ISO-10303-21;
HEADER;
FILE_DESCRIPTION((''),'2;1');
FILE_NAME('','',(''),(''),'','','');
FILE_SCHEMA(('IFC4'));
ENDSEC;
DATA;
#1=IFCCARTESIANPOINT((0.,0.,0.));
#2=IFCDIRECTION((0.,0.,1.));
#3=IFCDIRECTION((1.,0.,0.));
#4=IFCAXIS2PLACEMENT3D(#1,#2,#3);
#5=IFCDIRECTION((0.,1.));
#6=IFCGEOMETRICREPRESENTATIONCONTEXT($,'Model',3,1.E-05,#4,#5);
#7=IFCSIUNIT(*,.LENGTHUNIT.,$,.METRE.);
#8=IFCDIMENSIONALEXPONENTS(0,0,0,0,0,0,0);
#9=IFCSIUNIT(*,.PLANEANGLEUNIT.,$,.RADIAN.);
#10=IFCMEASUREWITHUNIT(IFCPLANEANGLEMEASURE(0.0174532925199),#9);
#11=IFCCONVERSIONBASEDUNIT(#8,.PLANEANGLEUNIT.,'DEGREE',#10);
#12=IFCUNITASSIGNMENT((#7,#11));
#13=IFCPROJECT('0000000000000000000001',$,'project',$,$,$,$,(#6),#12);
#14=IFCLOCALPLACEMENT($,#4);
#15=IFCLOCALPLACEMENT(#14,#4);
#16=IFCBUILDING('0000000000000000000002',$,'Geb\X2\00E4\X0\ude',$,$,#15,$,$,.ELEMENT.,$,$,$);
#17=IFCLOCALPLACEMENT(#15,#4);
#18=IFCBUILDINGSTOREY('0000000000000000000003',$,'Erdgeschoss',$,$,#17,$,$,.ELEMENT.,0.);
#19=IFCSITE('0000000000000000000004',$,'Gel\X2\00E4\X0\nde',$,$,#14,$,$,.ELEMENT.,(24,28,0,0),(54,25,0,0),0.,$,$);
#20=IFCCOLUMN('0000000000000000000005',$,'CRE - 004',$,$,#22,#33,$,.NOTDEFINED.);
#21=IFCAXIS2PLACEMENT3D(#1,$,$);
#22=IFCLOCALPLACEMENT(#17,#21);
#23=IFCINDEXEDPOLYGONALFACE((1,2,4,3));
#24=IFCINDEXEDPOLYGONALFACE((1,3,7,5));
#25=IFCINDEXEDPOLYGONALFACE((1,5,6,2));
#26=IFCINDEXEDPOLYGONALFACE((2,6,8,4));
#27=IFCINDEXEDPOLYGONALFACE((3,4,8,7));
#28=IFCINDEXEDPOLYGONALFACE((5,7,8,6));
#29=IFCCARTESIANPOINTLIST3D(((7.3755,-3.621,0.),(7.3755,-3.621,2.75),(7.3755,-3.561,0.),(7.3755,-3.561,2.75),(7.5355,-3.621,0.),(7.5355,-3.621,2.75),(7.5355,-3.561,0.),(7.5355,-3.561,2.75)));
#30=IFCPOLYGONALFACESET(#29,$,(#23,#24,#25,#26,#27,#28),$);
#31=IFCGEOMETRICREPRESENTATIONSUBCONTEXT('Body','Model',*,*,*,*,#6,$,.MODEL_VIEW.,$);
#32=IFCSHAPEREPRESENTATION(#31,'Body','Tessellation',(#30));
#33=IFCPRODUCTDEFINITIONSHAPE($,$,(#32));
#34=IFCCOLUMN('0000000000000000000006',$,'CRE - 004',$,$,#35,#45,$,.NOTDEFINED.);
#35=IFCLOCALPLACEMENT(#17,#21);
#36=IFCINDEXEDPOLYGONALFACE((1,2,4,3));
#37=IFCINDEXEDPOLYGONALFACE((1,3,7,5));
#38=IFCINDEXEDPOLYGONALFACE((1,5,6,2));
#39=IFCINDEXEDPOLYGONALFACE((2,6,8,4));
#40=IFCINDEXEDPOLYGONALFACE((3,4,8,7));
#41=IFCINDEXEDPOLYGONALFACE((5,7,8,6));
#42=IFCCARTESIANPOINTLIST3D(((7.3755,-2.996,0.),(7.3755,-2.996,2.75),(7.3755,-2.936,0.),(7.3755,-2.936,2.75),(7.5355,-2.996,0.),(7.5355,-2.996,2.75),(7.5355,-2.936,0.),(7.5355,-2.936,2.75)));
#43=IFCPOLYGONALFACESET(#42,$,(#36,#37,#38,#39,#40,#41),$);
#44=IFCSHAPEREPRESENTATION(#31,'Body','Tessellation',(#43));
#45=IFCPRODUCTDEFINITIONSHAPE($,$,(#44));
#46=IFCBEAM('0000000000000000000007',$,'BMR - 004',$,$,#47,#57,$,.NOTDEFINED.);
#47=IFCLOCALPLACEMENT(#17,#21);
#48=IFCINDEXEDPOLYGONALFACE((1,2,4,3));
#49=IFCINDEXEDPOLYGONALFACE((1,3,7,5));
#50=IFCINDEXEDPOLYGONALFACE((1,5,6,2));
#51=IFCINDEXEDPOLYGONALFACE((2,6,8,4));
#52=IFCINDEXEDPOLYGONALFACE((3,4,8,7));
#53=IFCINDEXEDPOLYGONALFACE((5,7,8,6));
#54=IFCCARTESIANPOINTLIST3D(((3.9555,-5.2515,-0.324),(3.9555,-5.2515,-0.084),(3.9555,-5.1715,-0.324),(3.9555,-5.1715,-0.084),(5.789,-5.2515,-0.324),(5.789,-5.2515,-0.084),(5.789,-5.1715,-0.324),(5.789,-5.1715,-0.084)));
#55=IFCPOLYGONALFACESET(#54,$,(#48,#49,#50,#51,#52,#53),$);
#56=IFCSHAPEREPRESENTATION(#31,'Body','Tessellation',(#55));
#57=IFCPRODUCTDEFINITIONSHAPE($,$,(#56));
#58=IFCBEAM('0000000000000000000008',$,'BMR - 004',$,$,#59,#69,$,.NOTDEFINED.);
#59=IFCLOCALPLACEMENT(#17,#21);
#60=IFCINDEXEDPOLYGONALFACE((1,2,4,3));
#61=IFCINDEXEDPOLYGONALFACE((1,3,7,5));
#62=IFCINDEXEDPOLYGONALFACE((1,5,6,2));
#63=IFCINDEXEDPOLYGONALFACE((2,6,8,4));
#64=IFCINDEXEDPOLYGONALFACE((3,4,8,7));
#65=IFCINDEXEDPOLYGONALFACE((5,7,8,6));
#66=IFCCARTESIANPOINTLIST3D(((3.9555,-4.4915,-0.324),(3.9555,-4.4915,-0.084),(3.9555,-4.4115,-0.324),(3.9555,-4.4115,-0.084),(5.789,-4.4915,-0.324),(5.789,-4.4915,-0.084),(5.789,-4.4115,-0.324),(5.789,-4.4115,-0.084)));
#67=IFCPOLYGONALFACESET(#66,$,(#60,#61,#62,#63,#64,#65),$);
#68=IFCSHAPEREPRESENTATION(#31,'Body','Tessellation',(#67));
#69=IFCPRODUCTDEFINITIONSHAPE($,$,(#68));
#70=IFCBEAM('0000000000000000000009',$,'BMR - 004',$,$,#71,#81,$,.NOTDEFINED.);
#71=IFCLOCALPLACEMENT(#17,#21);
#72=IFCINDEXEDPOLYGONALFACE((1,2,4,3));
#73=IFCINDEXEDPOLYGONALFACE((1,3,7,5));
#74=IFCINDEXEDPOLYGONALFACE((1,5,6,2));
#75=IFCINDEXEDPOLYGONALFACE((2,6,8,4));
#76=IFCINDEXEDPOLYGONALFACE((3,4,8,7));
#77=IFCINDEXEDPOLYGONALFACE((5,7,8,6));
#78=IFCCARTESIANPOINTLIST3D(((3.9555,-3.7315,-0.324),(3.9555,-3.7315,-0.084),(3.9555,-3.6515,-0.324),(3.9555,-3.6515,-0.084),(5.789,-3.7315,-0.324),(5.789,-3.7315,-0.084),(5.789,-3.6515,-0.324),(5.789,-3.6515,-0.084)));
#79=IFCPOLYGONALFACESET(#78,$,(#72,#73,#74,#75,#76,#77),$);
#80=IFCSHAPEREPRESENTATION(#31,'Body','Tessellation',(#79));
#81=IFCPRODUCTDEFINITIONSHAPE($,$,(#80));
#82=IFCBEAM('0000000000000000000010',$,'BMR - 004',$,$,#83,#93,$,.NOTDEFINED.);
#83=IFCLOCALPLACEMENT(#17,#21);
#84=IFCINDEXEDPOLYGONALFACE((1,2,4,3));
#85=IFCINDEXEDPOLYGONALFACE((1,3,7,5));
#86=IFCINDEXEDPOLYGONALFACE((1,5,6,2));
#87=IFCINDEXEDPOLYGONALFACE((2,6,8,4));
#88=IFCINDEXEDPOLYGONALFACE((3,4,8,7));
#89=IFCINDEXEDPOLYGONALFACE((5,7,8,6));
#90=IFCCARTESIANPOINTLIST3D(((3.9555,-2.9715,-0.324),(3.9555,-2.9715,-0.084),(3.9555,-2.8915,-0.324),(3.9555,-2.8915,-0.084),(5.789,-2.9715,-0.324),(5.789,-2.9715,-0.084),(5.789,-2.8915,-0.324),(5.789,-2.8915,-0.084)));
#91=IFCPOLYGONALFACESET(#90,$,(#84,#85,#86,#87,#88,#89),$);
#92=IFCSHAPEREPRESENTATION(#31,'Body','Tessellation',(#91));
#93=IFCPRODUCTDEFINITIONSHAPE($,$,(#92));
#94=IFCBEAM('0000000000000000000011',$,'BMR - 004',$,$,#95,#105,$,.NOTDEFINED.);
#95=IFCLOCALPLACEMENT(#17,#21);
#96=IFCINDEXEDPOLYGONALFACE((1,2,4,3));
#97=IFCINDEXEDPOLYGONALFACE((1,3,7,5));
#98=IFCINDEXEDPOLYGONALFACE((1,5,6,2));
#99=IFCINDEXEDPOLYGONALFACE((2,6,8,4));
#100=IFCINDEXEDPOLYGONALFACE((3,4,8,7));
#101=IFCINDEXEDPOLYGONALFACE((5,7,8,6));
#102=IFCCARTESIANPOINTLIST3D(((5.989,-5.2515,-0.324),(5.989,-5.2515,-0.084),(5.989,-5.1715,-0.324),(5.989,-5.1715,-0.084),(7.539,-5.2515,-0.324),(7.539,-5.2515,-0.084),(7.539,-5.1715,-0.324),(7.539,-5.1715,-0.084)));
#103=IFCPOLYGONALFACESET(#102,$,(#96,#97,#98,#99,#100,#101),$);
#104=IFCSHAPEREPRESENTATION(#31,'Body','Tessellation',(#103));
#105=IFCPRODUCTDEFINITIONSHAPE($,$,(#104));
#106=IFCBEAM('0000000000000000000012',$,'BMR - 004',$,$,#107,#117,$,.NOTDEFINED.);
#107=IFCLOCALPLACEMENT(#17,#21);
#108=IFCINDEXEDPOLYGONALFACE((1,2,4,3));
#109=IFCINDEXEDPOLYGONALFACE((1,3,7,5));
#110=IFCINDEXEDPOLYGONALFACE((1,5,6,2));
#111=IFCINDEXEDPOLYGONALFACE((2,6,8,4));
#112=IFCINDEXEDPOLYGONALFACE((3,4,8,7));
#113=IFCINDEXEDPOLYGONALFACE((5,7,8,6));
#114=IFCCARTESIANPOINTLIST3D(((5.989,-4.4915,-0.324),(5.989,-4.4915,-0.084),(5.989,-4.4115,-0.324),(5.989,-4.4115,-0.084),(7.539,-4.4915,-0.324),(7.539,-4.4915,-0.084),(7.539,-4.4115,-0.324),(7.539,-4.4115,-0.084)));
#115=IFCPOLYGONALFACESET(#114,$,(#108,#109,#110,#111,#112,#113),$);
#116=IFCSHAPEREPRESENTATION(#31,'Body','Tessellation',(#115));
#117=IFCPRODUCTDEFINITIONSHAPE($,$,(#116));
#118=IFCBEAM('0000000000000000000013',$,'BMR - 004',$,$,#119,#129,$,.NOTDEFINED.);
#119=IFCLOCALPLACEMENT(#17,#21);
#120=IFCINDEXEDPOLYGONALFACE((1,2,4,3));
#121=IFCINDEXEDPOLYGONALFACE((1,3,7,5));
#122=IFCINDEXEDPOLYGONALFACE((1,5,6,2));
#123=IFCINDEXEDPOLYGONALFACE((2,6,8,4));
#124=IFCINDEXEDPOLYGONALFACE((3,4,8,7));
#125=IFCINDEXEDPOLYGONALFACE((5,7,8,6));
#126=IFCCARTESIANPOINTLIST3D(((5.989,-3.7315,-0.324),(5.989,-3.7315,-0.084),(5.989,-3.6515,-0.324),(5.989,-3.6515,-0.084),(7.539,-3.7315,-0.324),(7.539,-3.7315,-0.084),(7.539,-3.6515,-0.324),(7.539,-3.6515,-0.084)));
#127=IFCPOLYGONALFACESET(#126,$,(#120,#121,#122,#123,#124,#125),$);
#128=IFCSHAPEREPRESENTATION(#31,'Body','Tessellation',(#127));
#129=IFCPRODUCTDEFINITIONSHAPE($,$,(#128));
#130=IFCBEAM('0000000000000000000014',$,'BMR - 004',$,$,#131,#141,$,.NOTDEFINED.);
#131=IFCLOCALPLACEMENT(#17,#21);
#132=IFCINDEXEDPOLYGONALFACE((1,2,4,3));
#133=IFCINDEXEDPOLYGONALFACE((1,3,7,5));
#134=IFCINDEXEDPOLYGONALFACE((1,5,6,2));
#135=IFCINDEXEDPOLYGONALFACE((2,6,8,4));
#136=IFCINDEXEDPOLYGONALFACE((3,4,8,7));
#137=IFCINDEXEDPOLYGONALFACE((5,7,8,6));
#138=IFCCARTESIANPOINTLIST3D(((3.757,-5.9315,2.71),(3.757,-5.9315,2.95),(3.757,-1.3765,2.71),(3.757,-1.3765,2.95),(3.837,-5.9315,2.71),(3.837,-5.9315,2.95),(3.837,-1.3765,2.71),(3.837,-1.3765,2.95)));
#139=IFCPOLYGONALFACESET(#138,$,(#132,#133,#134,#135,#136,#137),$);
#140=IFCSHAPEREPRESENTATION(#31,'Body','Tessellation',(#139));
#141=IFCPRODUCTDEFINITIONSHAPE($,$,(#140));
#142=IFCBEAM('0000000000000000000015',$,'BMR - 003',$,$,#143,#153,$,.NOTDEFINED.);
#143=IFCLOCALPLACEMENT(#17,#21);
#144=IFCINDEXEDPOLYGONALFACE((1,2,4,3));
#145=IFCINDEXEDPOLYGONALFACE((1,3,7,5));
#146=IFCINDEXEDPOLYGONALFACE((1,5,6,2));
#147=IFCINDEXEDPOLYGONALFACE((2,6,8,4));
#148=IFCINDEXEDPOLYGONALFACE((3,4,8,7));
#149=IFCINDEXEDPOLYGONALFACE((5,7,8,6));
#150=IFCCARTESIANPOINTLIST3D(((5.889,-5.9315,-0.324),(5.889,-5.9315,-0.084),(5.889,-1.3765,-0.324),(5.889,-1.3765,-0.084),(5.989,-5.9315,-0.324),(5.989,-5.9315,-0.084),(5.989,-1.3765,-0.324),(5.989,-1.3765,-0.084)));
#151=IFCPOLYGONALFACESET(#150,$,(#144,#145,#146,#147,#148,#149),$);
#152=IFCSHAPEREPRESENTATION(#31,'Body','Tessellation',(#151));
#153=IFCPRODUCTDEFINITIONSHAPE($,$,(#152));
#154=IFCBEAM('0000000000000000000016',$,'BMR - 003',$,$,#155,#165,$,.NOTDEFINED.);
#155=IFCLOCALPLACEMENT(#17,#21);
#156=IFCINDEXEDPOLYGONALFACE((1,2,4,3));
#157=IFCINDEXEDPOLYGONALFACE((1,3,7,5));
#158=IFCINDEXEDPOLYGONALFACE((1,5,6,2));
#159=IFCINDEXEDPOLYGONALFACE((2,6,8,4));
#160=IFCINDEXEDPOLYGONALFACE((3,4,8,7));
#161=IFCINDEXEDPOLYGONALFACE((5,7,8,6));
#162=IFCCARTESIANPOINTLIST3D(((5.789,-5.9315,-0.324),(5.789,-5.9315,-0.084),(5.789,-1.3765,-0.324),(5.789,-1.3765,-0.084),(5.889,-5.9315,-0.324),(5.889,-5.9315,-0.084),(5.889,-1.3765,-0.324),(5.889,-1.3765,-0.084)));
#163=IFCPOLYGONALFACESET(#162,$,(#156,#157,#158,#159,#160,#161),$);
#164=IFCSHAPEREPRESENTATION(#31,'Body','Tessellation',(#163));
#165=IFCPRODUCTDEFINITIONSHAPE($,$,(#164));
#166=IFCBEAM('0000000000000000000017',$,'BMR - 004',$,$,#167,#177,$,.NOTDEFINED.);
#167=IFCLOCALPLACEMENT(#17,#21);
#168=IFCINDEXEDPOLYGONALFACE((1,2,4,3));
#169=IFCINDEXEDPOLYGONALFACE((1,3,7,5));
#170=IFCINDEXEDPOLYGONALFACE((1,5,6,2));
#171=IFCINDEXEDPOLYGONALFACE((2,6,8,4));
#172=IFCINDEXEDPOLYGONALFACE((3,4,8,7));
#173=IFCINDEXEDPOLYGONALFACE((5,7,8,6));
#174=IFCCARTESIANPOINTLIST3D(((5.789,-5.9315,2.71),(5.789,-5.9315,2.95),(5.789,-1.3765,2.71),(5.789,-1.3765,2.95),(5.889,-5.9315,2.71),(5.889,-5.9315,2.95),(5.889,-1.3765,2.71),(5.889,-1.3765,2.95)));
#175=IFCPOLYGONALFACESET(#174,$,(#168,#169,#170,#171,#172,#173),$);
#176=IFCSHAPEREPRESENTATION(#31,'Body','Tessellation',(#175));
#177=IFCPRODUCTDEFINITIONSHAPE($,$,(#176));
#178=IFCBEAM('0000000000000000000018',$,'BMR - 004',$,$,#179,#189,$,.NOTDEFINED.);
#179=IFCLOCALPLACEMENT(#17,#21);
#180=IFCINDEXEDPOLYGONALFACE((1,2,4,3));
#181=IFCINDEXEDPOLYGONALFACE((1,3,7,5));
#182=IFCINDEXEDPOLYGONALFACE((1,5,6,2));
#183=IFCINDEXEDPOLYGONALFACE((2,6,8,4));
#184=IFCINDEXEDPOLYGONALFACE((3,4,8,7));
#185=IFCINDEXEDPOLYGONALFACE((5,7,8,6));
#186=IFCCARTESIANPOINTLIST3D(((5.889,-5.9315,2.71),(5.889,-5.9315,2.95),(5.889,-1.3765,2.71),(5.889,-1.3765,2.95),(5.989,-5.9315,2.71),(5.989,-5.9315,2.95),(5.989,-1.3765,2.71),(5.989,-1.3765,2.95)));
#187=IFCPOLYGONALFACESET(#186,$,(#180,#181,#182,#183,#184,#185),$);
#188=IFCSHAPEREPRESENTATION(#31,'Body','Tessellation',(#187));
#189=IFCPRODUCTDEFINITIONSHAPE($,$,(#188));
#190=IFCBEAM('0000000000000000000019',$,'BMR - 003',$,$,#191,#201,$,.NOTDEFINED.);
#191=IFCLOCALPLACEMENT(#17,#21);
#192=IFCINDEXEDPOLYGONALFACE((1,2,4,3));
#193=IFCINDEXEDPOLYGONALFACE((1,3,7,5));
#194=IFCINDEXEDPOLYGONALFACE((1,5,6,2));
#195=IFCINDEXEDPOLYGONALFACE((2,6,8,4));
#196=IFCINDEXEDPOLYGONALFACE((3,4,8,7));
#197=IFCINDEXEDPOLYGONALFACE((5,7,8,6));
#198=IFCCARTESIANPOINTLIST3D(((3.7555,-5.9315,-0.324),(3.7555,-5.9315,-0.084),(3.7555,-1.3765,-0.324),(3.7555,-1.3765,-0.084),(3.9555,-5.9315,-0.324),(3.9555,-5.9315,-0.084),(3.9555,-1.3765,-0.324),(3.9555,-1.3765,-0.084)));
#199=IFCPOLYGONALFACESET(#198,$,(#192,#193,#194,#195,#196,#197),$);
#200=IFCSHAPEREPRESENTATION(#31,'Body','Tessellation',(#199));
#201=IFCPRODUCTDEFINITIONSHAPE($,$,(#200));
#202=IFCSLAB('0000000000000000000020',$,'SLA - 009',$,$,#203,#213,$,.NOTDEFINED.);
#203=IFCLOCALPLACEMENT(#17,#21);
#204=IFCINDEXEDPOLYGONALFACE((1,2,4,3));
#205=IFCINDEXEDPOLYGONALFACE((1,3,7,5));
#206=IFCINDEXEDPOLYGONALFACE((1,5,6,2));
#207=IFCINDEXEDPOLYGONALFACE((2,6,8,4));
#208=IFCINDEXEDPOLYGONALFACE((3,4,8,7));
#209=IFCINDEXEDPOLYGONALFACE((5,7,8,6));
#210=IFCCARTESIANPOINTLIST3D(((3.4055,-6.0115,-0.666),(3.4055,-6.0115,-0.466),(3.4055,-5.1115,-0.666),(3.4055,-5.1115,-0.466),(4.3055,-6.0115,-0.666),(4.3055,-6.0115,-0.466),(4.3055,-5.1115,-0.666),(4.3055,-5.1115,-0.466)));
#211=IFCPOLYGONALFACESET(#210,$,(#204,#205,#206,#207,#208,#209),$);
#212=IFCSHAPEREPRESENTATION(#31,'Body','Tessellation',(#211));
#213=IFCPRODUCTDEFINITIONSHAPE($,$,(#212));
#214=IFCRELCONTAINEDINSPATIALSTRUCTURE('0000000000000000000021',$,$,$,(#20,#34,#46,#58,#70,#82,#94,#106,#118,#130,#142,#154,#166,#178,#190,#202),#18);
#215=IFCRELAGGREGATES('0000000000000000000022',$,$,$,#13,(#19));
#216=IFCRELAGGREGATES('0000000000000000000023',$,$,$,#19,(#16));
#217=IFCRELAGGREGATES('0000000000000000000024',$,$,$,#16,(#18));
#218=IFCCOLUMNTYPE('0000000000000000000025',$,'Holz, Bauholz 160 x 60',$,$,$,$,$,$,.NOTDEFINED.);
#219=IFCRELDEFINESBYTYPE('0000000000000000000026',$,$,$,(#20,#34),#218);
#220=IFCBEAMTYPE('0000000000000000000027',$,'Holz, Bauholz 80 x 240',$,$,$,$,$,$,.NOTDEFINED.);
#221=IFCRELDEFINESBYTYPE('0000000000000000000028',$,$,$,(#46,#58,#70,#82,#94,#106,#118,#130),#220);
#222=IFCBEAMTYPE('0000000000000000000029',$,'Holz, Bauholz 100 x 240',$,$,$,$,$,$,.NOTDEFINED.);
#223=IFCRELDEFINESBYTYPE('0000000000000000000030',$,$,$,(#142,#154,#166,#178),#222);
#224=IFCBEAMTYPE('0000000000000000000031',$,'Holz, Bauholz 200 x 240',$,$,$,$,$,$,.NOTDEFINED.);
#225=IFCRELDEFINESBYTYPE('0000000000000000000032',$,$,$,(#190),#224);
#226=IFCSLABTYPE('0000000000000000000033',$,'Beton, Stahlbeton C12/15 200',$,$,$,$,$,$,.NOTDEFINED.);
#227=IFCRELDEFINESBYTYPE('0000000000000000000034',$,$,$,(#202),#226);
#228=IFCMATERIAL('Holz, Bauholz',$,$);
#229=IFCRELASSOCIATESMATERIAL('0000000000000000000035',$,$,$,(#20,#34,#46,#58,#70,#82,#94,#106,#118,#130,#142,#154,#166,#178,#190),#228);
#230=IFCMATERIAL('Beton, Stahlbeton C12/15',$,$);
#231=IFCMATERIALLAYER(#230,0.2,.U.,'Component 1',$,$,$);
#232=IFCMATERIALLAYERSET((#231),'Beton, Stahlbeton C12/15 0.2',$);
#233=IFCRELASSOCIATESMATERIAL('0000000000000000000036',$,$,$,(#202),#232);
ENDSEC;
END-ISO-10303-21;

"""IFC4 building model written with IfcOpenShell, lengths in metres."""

from ifc_helpers import new_model, entity, si_unit, converted_unit, direction, frame, frame_2d, origin_with_axes, origin_2d_with_axis, place, context, subcontext, project, spatial, line, indexed_curve, rectangle, outline, extrude, material, layer, layer_set, layer_usage, type_object, element, save


model = new_model("IFC4")

# Units and contexts
model_context = context("Model", 3, precision=1e-05, world=origin_with_axes(), true_north=direction((0.0, 1.0)))
body_context = subcontext(model_context, "Body", "Model", "MODEL_VIEW")
ifc_project = project(units=[si_unit("LENGTHUNIT", "METRE"), converted_unit("PLANEANGLEUNIT", "DEGREE", entity("IfcPlaneAngleMeasure", 0.0174532925199), si_unit("PLANEANGLEUNIT", "RADIAN"), dimensions=[0, 0, 0, 0, 0, 0, 0])], contexts=[model_context])

# Site, building, storey
site_placement = place(None, origin_with_axes())
site = spatial("IfcSite", under=ifc_project, at=site_placement, Name="Gelände", CompositionType="ELEMENT", RefLatitude=(24, 28, 0, 0), RefLongitude=(54, 25, 0, 0), RefElevation=0.0)
building_placement = place(site_placement, origin_with_axes())
building = spatial("IfcBuilding", under=site, at=building_placement, Name="Gebäude", CompositionType="ELEMENT")
storey_placement = place(building_placement, origin_with_axes())
storey = spatial("IfcBuildingStorey", under=building, at=storey_placement, Name="Erdgeschoss", CompositionType="ELEMENT", Elevation=0.0)

# Columns
ifc_material_1 = material(Name="Holz, Bauholz")
column_type_1 = type_object("IfcColumnType", Name="Holz, Bauholz 160 x 60", PredefinedType="NOTDEFINED")
for number, where, z_axis, x_axis, name in (
    (1, (7.4555, -3.591, 0.0), (0.0, 0.0, 1.0), (0.0, -1.0, 0.0), "CRE - 004"),
    (2, (7.4555, -2.966, 0.0), (0.0, 0.0, 1.0), (0.0, -1.0, 0.0), "CRE - 004"),
):
    element("IfcColumn", number, at=place(storey_placement, frame(where, z_axis=z_axis, x_axis=x_axis)), inside=storey, type_object=column_type_1, material=ifc_material_1, Name=name, PredefinedType="NOTDEFINED", context=body_context, shape_type="SweptSolid", body=[
        extrude(rectangle(XDim=0.16, YDim=0.06, at=origin_2d_with_axis()), frame((0.0, 0.0, 0.0), z_axis=(0.0, 0.0, 1.0), x_axis=(0.0, 1.0, 0.0)), (0.0, 0.0, 1.0), 2.75),
    ])

# Beams
beam_type_1 = type_object("IfcBeamType", Name="Holz, Bauholz 80 x 240", PredefinedType="NOTDEFINED")
for number, where, z_axis, x_axis, name in (
    (3, (5.789, -5.2115, -0.084), (0.0, 0.0, 1.0), (0.0, 1.0, 0.0), "BMR - 004"),
    (4, (5.789, -4.4515, -0.084), (0.0, 0.0, 1.0), (0.0, 1.0, 0.0), "BMR - 004"),
    (5, (5.789, -3.6915, -0.084), (0.0, 0.0, 1.0), (0.0, 1.0, 0.0), "BMR - 004"),
    (6, (5.789, -2.9315, -0.084), (0.0, 0.0, 1.0), (0.0, 1.0, 0.0), "BMR - 004"),
):
    element("IfcBeam", number, at=place(storey_placement, frame(where, z_axis=z_axis, x_axis=x_axis)), inside=storey, type_object=beam_type_1, material=ifc_material_1, Name=name, PredefinedType="NOTDEFINED", context=body_context, shape_type="SweptSolid", body=[
        extrude(rectangle(XDim=0.24, YDim=0.08, at=frame_2d((-0.12, 0.0), x_axis=(1.0, 0.0))), frame((0.0, 0.0, 0.0), z_axis=(0.0, 1.0, 0.0), x_axis=(0.0, 0.0, 1.0)), (0.0, 0.0, 1.0), 1.8335),
    ])
for number, where, z_axis, x_axis, name in (
    (7, (7.539, -5.2115, -0.084), (0.0, 0.0, 1.0), (0.0, 1.0, 0.0), "BMR - 004"),
    (8, (7.539, -4.4515, -0.084), (0.0, 0.0, 1.0), (0.0, 1.0, 0.0), "BMR - 004"),
    (9, (7.539, -3.6915, -0.084), (0.0, 0.0, 1.0), (0.0, 1.0, 0.0), "BMR - 004"),
):
    element("IfcBeam", number, at=place(storey_placement, frame(where, z_axis=z_axis, x_axis=x_axis)), inside=storey, type_object=beam_type_1, material=ifc_material_1, Name=name, PredefinedType="NOTDEFINED", context=body_context, shape_type="SweptSolid", body=[
        extrude(rectangle(XDim=0.24, YDim=0.08, at=frame_2d((-0.12, 0.0), x_axis=(1.0, 0.0))), frame((0.0, 0.0, 0.0), z_axis=(0.0, 1.0, 0.0), x_axis=(0.0, 0.0, 1.0)), (0.0, 0.0, 1.0), 1.55),
    ])
beam_1_placement = place(storey_placement, frame((3.797, -5.9315, 2.95), z_axis=(0.0, 0.0, 1.0), x_axis=(1.0, 0.0, 0.0)))
element("IfcBeam", 10, at=beam_1_placement, inside=storey, type_object=beam_type_1, material=ifc_material_1, Name="BMR - 004", PredefinedType="NOTDEFINED", context=body_context, shape_type="SweptSolid", body=[
    extrude(rectangle(XDim=0.24, YDim=0.08, at=frame_2d((-0.12, 0.0), x_axis=(1.0, 0.0))), frame((0.0, 0.0, 0.0), z_axis=(0.0, 1.0, 0.0), x_axis=(0.0, 0.0, 1.0)), (0.0, 0.0, 1.0), 4.555),
])
beam_type_2 = type_object("IfcBeamType", Name="Holz, Bauholz 100 x 240", PredefinedType="NOTDEFINED")
for number, where, z_axis, x_axis, name in (
    (11, (5.939, -5.9315, -0.084), (0.0, 0.0, 1.0), (1.0, 0.0, 0.0), "BMR - 003"),
    (12, (5.839, -5.9315, -0.084), (0.0, 0.0, 1.0), (1.0, 0.0, 0.0), "BMR - 003"),
):
    element("IfcBeam", number, at=place(storey_placement, frame(where, z_axis=z_axis, x_axis=x_axis)), inside=storey, type_object=beam_type_2, material=ifc_material_1, Name=name, PredefinedType="NOTDEFINED", context=body_context, shape_type="SweptSolid", body=[
        extrude(rectangle(XDim=0.24, YDim=0.1, at=frame_2d((-0.12, 0.0), x_axis=(1.0, 0.0))), frame((0.0, 0.0, 0.0), z_axis=(0.0, 1.0, 0.0), x_axis=(0.0, 0.0, 1.0)), (0.0, 0.0, 1.0), 4.555),
    ])
for number, where, z_axis, x_axis, name in (
    (13, (5.839, -5.9315, 2.95), (0.0, 0.0, 1.0), (1.0, 0.0, 0.0), "BMR - 004"),
    (14, (5.939, -5.9315, 2.95), (0.0, 0.0, 1.0), (1.0, 0.0, 0.0), "BMR - 004"),
):
    element("IfcBeam", number, at=place(storey_placement, frame(where, z_axis=z_axis, x_axis=x_axis)), inside=storey, type_object=beam_type_2, material=ifc_material_1, Name=name, PredefinedType="NOTDEFINED", context=body_context, shape_type="SweptSolid", body=[
        extrude(rectangle(XDim=0.24, YDim=0.1, at=frame_2d((-0.12, 0.0), x_axis=(1.0, 0.0))), frame((0.0, 0.0, 0.0), z_axis=(0.0, 1.0, 0.0), x_axis=(0.0, 0.0, 1.0)), (0.0, 0.0, 1.0), 4.555),
    ])
beam_type_3 = type_object("IfcBeamType", Name="Holz, Bauholz 200 x 240", PredefinedType="NOTDEFINED")
beam_2_placement = place(storey_placement, frame((3.8555, -5.9315, -0.084), z_axis=(0.0, 0.0, 1.0), x_axis=(1.0, 0.0, 0.0)))
element("IfcBeam", 15, at=beam_2_placement, inside=storey, type_object=beam_type_3, material=ifc_material_1, Name="BMR - 003", PredefinedType="NOTDEFINED", context=body_context, shape_type="SweptSolid", body=[
    extrude(rectangle(XDim=0.24, YDim=0.2, at=frame_2d((-0.12, 0.0), x_axis=(1.0, 0.0))), frame((0.0, 0.0, 0.0), z_axis=(0.0, 1.0, 0.0), x_axis=(0.0, 0.0, 1.0)), (0.0, 0.0, 1.0), 4.555),
])

# Slab
ifc_material_2 = material(Name="Beton, Stahlbeton C12/15")
ifc_layer = layer(ifc_material_2, 0.2, ventilated="UNKNOWN", Name="Component 1")
ifc_layer_set = layer_set([ifc_layer], Name="Beton, Stahlbeton C12/15 0.2")
ifc_layer_usage_1 = layer_usage(ifc_layer_set, "AXIS3", "NEGATIVE", 0.2)
slab_type = type_object("IfcSlabType", Name="Beton, Stahlbeton C12/15 200", PredefinedType="NOTDEFINED")
slab_1_placement = place(storey_placement, frame((3.4055, -6.0115, -0.466), z_axis=(0.0, 0.0, 1.0), x_axis=(1.0, 0.0, 0.0)))
element("IfcSlab", 16, at=slab_1_placement, inside=storey, type_object=slab_type, material=ifc_layer_usage_1, Name="SLA - 009", PredefinedType="NOTDEFINED", context=body_context, shape_type="SweptSolid", body=[
    extrude(outline(indexed_curve([(0.0, 0.0), (0.9, 0.0), (0.9, 0.9), (0.0, 0.9)], segments=[line(1, 2, 3, 4, 1)])), frame((0.0, 0.0, -0.2), z_axis=(0.0, 0.0, 1.0), x_axis=(1.0, 0.0, 0.0)), (0.0, 0.0, 1.0), 0.2),
])

save(model, "model.ifc")
